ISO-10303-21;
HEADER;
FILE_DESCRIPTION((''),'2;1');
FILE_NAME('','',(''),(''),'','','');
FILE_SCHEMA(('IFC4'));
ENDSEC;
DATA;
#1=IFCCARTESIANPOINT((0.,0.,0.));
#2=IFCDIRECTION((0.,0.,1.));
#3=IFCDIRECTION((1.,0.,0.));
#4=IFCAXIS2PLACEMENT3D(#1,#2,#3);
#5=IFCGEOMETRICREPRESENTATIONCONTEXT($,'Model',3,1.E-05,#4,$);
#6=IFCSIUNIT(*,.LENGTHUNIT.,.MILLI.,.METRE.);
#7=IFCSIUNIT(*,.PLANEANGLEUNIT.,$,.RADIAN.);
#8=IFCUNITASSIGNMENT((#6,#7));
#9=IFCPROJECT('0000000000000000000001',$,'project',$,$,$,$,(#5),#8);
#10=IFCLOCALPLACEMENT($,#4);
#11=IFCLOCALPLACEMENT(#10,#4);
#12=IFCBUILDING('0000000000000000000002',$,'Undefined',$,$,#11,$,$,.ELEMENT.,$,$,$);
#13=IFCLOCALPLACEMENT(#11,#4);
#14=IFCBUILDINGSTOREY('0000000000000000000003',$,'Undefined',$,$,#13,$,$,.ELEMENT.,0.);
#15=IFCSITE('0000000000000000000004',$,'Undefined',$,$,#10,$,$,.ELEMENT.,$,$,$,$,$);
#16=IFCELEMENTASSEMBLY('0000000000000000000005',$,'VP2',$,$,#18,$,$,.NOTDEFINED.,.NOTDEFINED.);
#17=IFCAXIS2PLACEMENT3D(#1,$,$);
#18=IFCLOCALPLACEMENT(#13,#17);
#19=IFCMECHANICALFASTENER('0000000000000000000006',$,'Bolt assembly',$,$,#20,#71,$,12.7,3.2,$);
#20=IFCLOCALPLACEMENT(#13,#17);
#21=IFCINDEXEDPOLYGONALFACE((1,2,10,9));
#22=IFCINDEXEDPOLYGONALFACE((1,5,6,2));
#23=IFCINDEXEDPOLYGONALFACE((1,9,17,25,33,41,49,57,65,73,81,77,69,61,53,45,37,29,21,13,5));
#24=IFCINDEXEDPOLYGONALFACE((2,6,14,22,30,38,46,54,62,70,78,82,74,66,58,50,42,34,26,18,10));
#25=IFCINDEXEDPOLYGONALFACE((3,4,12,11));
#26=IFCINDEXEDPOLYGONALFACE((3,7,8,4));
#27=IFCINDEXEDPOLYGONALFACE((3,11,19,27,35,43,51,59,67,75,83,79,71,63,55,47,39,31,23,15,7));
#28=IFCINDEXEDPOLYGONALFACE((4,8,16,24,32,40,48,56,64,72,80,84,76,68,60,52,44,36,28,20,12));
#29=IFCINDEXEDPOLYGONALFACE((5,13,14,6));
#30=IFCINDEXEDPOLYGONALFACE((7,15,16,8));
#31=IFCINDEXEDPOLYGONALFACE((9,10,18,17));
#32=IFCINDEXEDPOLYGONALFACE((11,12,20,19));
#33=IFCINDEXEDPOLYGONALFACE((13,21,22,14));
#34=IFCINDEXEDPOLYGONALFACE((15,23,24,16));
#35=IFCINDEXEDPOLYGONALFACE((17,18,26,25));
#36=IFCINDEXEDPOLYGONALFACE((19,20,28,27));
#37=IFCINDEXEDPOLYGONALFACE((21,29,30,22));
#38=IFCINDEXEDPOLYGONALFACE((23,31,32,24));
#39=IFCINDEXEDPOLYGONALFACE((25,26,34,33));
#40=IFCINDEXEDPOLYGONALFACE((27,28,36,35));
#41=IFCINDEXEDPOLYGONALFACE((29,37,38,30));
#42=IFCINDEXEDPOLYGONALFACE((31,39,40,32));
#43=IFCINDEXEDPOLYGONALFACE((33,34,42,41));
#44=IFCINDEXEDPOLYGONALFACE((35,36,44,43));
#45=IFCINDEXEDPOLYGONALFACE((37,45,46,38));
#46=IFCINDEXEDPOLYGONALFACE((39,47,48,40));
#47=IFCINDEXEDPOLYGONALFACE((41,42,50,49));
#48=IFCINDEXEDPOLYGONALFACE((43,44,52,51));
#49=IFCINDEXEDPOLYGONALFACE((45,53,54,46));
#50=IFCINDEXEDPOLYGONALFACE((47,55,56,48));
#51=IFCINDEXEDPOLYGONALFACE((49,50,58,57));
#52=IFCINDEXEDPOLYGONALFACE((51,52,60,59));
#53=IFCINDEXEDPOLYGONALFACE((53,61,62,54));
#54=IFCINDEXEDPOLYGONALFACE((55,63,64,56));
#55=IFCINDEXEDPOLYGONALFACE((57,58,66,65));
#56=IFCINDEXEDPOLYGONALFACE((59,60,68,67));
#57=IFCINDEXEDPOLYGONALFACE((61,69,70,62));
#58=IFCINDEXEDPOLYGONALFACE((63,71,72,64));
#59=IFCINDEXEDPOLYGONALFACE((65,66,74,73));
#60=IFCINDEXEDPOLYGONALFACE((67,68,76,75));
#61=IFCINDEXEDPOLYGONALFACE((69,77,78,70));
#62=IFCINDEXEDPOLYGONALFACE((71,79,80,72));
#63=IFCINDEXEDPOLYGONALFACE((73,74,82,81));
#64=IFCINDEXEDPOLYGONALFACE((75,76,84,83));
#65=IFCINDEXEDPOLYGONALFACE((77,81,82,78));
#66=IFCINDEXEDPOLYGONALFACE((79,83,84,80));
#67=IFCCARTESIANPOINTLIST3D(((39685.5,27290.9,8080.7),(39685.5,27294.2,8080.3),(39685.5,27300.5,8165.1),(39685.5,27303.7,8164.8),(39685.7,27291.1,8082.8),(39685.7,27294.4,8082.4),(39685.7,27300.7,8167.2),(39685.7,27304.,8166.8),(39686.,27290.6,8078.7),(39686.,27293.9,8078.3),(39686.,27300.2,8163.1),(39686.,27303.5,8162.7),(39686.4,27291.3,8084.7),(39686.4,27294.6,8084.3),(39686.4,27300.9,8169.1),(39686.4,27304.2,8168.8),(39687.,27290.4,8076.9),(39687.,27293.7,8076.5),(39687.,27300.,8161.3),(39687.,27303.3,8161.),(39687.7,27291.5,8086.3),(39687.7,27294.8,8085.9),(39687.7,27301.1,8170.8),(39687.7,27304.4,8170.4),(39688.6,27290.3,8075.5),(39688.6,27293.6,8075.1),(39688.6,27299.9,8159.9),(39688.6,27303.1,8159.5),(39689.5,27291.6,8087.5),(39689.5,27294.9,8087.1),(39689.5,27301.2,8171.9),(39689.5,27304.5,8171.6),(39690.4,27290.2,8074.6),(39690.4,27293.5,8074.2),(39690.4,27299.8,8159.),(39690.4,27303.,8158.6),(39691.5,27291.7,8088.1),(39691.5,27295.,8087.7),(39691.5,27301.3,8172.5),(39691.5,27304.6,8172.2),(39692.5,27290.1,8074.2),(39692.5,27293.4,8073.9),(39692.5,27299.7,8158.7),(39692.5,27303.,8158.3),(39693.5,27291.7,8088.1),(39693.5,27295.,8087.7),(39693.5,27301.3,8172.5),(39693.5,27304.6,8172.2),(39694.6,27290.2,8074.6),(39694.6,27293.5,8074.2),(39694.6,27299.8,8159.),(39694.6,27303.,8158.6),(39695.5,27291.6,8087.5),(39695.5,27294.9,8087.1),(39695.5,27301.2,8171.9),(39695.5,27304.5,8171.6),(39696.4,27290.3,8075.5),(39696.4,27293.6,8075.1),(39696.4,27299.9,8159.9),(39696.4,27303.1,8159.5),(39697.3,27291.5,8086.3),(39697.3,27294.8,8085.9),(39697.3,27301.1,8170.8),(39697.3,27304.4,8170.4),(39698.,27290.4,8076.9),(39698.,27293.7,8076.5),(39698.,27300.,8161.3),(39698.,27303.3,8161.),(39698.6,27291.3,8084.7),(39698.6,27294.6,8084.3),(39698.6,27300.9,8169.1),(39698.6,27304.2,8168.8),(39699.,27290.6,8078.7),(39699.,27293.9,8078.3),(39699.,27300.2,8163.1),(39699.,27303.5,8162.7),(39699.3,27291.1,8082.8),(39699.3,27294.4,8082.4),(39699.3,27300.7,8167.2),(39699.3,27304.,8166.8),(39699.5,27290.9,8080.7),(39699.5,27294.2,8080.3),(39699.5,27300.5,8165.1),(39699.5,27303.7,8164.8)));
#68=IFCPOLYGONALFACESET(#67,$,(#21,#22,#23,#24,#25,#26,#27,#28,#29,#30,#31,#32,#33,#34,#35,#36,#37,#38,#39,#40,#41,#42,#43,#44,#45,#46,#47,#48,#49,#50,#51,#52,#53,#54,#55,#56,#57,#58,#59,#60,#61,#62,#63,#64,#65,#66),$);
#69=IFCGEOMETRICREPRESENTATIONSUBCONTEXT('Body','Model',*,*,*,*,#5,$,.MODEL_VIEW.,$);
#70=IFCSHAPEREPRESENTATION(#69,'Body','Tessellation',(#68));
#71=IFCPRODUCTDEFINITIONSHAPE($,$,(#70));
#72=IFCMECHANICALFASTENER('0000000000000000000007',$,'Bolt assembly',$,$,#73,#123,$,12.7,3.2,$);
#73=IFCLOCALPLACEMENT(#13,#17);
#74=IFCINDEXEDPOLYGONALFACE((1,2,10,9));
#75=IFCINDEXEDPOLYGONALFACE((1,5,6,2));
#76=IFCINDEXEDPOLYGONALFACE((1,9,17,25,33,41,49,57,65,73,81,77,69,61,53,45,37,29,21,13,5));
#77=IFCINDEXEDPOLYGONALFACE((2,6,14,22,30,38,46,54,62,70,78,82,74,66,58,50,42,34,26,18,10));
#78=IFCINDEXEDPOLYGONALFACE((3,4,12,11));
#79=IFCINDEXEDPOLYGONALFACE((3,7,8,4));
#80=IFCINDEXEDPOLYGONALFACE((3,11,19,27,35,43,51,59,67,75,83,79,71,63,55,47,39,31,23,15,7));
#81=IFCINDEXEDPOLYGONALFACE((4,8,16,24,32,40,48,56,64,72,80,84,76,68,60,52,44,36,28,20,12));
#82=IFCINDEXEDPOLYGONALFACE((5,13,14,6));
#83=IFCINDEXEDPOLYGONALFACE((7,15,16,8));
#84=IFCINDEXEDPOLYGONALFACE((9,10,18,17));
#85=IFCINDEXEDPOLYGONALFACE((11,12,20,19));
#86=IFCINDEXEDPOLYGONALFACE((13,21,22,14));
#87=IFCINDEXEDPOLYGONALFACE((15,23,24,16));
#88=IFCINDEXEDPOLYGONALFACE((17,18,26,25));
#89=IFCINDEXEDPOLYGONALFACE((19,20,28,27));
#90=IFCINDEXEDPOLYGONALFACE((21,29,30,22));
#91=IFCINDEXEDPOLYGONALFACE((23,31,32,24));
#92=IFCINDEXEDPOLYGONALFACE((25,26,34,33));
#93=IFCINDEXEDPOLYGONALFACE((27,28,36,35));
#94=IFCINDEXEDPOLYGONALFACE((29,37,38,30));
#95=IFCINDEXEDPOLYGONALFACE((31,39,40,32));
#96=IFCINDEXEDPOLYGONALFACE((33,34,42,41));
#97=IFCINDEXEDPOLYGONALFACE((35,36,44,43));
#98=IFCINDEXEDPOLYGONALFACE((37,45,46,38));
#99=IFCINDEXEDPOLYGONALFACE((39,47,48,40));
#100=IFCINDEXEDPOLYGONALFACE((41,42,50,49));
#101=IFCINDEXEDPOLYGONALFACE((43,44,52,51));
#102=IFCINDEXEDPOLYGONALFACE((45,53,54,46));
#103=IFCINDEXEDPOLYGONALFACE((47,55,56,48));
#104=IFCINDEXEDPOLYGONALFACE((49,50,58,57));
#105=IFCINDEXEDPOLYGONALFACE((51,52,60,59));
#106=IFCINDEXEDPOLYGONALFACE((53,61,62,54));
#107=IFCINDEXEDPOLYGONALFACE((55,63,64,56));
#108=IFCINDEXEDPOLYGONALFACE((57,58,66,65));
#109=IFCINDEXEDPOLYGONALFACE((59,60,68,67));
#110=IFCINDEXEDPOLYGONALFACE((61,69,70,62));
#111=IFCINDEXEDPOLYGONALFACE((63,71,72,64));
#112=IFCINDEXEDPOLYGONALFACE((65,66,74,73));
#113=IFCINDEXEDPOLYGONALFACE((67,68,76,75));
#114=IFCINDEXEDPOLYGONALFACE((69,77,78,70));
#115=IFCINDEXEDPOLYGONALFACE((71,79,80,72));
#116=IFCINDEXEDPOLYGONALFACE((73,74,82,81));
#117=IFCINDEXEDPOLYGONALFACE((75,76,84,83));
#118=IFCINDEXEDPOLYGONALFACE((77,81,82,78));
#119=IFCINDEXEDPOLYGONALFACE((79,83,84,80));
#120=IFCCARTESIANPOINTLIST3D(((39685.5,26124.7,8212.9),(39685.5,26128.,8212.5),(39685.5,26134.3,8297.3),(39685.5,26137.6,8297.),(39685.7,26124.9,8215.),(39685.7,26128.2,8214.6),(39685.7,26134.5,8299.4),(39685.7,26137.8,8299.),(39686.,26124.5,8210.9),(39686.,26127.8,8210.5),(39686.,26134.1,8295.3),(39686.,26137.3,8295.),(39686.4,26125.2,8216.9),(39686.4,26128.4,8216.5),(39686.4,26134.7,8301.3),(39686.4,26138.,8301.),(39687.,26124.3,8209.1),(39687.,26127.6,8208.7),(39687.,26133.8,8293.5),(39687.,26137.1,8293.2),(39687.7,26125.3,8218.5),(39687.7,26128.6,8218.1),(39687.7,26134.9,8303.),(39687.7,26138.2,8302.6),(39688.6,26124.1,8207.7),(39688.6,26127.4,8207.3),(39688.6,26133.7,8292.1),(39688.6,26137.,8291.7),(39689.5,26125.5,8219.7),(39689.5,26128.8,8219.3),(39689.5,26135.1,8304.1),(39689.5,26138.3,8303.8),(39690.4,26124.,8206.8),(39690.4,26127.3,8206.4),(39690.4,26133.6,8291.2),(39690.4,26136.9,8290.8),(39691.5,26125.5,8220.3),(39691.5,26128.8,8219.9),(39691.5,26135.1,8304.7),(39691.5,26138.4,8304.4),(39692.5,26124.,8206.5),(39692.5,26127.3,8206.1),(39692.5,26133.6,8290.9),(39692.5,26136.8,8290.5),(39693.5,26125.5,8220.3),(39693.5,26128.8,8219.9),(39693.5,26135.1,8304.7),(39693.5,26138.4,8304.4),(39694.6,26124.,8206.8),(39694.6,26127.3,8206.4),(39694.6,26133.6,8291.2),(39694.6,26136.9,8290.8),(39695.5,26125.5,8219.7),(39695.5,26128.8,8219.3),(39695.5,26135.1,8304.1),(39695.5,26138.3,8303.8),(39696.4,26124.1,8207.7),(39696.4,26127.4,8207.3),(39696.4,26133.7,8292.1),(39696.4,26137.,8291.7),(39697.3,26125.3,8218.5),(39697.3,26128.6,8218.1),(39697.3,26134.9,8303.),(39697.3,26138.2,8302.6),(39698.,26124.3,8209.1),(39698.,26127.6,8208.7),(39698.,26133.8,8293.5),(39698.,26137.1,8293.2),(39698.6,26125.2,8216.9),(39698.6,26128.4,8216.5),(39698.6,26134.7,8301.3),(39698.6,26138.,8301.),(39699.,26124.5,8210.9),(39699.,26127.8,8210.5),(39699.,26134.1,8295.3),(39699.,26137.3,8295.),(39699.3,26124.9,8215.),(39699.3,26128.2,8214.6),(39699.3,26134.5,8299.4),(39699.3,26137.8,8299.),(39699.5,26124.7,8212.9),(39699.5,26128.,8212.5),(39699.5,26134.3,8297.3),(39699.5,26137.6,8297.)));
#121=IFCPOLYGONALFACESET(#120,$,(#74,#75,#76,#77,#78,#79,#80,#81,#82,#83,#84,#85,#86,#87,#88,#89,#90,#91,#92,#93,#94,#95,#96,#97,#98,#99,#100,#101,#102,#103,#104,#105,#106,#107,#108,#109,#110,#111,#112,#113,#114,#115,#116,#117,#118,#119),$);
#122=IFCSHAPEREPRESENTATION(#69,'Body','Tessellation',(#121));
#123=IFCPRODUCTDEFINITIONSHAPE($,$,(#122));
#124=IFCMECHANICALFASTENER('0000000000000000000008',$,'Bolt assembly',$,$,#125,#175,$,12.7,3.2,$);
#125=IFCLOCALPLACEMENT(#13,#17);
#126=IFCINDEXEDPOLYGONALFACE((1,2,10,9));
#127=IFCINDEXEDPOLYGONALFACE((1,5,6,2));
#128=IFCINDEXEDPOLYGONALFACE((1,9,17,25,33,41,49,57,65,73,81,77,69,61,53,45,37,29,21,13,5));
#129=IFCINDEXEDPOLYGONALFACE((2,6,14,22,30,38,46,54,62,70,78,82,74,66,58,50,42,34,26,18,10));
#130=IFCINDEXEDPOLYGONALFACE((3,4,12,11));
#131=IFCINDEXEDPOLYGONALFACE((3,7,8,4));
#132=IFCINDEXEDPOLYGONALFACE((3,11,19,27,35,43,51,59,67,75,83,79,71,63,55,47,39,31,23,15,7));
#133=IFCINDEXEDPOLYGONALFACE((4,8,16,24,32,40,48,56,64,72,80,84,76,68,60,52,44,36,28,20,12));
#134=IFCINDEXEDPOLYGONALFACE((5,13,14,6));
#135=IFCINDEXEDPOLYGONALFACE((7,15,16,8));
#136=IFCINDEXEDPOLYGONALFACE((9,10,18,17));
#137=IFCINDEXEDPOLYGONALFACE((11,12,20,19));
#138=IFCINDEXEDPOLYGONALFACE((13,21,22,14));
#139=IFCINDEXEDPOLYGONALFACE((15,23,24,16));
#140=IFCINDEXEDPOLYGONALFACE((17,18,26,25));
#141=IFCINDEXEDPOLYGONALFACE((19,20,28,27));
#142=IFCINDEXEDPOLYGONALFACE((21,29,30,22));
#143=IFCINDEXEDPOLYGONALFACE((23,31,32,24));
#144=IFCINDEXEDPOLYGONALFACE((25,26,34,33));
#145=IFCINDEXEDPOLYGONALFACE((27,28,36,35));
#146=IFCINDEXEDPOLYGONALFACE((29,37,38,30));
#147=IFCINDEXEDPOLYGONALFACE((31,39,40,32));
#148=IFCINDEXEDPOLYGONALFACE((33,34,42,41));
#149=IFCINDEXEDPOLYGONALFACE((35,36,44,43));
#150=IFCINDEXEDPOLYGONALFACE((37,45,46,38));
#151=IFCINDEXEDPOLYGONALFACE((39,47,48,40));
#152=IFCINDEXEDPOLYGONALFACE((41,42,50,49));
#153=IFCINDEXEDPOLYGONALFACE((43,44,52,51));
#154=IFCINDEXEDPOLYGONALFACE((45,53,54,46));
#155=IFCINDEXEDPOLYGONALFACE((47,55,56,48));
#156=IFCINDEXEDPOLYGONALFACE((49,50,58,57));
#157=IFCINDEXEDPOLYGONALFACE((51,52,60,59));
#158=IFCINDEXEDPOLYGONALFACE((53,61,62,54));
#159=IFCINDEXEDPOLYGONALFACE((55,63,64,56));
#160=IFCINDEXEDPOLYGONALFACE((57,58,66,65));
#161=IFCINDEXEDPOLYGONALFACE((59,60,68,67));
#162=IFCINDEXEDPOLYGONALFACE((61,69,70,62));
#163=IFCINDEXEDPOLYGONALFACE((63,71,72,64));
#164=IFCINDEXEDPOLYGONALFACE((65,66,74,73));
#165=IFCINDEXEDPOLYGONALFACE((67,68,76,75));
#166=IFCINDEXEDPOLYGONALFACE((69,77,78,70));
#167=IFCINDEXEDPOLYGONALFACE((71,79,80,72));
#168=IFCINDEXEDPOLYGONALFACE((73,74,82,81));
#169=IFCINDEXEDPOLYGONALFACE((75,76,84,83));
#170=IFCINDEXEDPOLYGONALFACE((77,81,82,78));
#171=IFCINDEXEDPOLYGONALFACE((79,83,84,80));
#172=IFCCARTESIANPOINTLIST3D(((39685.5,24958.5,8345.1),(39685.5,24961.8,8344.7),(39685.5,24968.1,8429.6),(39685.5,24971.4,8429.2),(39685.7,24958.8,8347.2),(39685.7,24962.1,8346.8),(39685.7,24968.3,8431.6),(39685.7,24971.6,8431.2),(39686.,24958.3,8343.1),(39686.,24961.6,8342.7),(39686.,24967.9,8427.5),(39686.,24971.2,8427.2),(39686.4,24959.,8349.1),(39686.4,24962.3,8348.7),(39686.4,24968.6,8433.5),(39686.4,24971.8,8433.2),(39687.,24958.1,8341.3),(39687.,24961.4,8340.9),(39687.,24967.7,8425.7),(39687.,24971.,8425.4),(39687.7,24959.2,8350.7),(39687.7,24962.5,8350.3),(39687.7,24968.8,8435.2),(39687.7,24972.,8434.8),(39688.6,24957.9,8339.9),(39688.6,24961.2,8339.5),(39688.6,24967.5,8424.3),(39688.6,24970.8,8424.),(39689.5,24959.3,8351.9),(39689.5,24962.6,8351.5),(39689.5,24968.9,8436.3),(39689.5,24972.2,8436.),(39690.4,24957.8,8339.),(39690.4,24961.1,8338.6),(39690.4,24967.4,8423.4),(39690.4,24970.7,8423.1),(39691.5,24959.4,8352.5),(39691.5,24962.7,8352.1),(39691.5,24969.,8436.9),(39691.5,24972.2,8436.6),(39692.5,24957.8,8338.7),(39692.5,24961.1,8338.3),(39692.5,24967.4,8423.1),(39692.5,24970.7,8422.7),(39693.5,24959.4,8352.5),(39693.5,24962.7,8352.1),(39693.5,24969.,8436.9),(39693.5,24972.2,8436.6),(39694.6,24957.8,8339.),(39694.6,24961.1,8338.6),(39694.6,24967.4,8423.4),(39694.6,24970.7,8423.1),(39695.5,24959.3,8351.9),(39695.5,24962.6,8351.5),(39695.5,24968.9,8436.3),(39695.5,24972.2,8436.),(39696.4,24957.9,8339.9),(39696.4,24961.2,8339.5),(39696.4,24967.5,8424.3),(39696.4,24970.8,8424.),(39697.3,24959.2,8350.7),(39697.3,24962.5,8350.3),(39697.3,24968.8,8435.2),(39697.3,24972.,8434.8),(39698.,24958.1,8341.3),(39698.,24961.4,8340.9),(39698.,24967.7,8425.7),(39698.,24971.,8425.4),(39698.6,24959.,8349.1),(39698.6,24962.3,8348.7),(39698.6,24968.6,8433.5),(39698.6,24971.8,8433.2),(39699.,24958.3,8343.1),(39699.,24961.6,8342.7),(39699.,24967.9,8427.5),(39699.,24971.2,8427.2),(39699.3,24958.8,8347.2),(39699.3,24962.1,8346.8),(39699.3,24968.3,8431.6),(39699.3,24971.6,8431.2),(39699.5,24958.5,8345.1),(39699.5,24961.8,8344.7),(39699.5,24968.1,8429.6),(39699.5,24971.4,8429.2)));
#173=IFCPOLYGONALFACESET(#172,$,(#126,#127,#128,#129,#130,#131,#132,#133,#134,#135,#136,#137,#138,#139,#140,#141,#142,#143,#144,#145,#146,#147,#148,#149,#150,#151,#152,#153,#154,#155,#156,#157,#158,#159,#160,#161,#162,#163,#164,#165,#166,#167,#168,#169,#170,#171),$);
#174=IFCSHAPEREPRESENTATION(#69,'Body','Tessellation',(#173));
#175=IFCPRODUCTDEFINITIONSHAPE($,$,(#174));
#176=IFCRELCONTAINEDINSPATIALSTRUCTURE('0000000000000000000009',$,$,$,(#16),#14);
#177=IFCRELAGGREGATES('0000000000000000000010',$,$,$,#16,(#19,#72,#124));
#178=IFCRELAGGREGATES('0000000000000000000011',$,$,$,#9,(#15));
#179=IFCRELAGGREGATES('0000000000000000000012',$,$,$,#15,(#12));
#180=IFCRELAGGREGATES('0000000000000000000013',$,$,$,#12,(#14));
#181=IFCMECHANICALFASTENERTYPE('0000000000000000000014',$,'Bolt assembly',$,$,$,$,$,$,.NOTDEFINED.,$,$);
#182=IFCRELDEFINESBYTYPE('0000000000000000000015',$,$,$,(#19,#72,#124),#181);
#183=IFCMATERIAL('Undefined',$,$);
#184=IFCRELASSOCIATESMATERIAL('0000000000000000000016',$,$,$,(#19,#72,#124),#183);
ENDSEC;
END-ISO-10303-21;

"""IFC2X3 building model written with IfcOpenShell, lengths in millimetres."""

from ifc_helpers import new_model, si_unit, frame, origin_with_axes, origin_2d_with_axis, place, context, subcontext, project, spatial, circle, extrude, source, transform, mapped, material, type_object, element, aggregate, save


model = new_model("IFC2X3")

# Units and contexts
model_context = context("Model", 3, precision=1e-05, world=origin_with_axes())
body_context = subcontext(model_context, "Body", "Model", "MODEL_VIEW")
ifc_project = project(units=[si_unit("LENGTHUNIT", "METRE", prefix="MILLI"), si_unit("PLANEANGLEUNIT", "RADIAN")], contexts=[model_context])

# Site, building, storey
site_placement = place(None, origin_with_axes())
site = spatial("IfcSite", under=ifc_project, at=site_placement, Name="Undefined", CompositionType="ELEMENT")
building_placement = place(site_placement, origin_with_axes())
building = spatial("IfcBuilding", under=site, at=building_placement, Name="Undefined", CompositionType="ELEMENT")
storey_placement = place(building_placement, origin_with_axes())
storey = spatial("IfcBuildingStorey", under=building, at=storey_placement, Name="Undefined", CompositionType="ELEMENT", Elevation=0.0)

# Element assembly
assembly_1_placement = place(storey_placement, origin_with_axes())
assembly_1 = element("IfcElementAssembly", 1, at=assembly_1_placement, inside=storey, Name="VP2", AssemblyPlace="NOTDEFINED", PredefinedType="NOTDEFINED")

# Shared definitions
ifc_material_1 = material(Name="Undefined")
mechanical_fastener_type = type_object("IfcMechanicalFastenerType", Name="Bolt assembly")

# Mechanical fasteners
shared_shape_1 = source(origin_with_axes(), body_context, "Body", "SweptSolid", [
    extrude(circle(Radius=7.0, at=origin_2d_with_axis()), frame((0.0, -3.2, 0.0), z_axis=(0.0, 1.0, 0.0), x_axis=(1.0, 0.0, 0.0)), (0.0, 0.0, 1.0), 3.3),
])
mechanical_fastener_1_placement = place(assembly_1_placement, frame((39692.5, 27303.7, 8165.3), z_axis=(1.0, 0.0, 0.0), x_axis=(0.0, -0.112644, -0.993635)))
mechanical_fastener_1 = element("IfcMechanicalFastener", 2, at=mechanical_fastener_1_placement, type_object=mechanical_fastener_type, material=ifc_material_1, Name="Bolt assembly", NominalDiameter=12.7, NominalLength=3.2, context=body_context, shape_type="MappedRepresentation", body=[
    mapped(shared_shape_1, transform((0.0, 0.0, 0.0))),
    mapped(shared_shape_1, transform((85.0, 0.0, 0.0))),
])
mechanical_fastener_2_placement = place(assembly_1_placement, frame((39692.5, 26137.5, 8297.5), z_axis=(1.0, 0.0, 0.0), x_axis=(0.0, -0.112644, -0.993635)))
mechanical_fastener_2 = element("IfcMechanicalFastener", 3, at=mechanical_fastener_2_placement, type_object=mechanical_fastener_type, material=ifc_material_1, Name="Bolt assembly", NominalDiameter=12.7, NominalLength=3.2, context=body_context, shape_type="MappedRepresentation", body=[
    mapped(shared_shape_1, transform((0.0, 0.0, 0.0))),
    mapped(shared_shape_1, transform((85.0, 0.0, 0.0))),
])
mechanical_fastener_3_placement = place(assembly_1_placement, frame((39692.5, 24971.4, 8429.7), z_axis=(1.0, 0.0, 0.0), x_axis=(0.0, -0.112644, -0.993635)))
mechanical_fastener_3 = element("IfcMechanicalFastener", 4, at=mechanical_fastener_3_placement, type_object=mechanical_fastener_type, material=ifc_material_1, Name="Bolt assembly", NominalDiameter=12.7, NominalLength=3.2, context=body_context, shape_type="MappedRepresentation", body=[
    mapped(shared_shape_1, transform((0.0, 0.0, 0.0))),
    mapped(shared_shape_1, transform((85.0, 0.0, 0.0))),
])
aggregate(assembly_1, [mechanical_fastener_1, mechanical_fastener_2, mechanical_fastener_3])

save(model, "model.ifc")
